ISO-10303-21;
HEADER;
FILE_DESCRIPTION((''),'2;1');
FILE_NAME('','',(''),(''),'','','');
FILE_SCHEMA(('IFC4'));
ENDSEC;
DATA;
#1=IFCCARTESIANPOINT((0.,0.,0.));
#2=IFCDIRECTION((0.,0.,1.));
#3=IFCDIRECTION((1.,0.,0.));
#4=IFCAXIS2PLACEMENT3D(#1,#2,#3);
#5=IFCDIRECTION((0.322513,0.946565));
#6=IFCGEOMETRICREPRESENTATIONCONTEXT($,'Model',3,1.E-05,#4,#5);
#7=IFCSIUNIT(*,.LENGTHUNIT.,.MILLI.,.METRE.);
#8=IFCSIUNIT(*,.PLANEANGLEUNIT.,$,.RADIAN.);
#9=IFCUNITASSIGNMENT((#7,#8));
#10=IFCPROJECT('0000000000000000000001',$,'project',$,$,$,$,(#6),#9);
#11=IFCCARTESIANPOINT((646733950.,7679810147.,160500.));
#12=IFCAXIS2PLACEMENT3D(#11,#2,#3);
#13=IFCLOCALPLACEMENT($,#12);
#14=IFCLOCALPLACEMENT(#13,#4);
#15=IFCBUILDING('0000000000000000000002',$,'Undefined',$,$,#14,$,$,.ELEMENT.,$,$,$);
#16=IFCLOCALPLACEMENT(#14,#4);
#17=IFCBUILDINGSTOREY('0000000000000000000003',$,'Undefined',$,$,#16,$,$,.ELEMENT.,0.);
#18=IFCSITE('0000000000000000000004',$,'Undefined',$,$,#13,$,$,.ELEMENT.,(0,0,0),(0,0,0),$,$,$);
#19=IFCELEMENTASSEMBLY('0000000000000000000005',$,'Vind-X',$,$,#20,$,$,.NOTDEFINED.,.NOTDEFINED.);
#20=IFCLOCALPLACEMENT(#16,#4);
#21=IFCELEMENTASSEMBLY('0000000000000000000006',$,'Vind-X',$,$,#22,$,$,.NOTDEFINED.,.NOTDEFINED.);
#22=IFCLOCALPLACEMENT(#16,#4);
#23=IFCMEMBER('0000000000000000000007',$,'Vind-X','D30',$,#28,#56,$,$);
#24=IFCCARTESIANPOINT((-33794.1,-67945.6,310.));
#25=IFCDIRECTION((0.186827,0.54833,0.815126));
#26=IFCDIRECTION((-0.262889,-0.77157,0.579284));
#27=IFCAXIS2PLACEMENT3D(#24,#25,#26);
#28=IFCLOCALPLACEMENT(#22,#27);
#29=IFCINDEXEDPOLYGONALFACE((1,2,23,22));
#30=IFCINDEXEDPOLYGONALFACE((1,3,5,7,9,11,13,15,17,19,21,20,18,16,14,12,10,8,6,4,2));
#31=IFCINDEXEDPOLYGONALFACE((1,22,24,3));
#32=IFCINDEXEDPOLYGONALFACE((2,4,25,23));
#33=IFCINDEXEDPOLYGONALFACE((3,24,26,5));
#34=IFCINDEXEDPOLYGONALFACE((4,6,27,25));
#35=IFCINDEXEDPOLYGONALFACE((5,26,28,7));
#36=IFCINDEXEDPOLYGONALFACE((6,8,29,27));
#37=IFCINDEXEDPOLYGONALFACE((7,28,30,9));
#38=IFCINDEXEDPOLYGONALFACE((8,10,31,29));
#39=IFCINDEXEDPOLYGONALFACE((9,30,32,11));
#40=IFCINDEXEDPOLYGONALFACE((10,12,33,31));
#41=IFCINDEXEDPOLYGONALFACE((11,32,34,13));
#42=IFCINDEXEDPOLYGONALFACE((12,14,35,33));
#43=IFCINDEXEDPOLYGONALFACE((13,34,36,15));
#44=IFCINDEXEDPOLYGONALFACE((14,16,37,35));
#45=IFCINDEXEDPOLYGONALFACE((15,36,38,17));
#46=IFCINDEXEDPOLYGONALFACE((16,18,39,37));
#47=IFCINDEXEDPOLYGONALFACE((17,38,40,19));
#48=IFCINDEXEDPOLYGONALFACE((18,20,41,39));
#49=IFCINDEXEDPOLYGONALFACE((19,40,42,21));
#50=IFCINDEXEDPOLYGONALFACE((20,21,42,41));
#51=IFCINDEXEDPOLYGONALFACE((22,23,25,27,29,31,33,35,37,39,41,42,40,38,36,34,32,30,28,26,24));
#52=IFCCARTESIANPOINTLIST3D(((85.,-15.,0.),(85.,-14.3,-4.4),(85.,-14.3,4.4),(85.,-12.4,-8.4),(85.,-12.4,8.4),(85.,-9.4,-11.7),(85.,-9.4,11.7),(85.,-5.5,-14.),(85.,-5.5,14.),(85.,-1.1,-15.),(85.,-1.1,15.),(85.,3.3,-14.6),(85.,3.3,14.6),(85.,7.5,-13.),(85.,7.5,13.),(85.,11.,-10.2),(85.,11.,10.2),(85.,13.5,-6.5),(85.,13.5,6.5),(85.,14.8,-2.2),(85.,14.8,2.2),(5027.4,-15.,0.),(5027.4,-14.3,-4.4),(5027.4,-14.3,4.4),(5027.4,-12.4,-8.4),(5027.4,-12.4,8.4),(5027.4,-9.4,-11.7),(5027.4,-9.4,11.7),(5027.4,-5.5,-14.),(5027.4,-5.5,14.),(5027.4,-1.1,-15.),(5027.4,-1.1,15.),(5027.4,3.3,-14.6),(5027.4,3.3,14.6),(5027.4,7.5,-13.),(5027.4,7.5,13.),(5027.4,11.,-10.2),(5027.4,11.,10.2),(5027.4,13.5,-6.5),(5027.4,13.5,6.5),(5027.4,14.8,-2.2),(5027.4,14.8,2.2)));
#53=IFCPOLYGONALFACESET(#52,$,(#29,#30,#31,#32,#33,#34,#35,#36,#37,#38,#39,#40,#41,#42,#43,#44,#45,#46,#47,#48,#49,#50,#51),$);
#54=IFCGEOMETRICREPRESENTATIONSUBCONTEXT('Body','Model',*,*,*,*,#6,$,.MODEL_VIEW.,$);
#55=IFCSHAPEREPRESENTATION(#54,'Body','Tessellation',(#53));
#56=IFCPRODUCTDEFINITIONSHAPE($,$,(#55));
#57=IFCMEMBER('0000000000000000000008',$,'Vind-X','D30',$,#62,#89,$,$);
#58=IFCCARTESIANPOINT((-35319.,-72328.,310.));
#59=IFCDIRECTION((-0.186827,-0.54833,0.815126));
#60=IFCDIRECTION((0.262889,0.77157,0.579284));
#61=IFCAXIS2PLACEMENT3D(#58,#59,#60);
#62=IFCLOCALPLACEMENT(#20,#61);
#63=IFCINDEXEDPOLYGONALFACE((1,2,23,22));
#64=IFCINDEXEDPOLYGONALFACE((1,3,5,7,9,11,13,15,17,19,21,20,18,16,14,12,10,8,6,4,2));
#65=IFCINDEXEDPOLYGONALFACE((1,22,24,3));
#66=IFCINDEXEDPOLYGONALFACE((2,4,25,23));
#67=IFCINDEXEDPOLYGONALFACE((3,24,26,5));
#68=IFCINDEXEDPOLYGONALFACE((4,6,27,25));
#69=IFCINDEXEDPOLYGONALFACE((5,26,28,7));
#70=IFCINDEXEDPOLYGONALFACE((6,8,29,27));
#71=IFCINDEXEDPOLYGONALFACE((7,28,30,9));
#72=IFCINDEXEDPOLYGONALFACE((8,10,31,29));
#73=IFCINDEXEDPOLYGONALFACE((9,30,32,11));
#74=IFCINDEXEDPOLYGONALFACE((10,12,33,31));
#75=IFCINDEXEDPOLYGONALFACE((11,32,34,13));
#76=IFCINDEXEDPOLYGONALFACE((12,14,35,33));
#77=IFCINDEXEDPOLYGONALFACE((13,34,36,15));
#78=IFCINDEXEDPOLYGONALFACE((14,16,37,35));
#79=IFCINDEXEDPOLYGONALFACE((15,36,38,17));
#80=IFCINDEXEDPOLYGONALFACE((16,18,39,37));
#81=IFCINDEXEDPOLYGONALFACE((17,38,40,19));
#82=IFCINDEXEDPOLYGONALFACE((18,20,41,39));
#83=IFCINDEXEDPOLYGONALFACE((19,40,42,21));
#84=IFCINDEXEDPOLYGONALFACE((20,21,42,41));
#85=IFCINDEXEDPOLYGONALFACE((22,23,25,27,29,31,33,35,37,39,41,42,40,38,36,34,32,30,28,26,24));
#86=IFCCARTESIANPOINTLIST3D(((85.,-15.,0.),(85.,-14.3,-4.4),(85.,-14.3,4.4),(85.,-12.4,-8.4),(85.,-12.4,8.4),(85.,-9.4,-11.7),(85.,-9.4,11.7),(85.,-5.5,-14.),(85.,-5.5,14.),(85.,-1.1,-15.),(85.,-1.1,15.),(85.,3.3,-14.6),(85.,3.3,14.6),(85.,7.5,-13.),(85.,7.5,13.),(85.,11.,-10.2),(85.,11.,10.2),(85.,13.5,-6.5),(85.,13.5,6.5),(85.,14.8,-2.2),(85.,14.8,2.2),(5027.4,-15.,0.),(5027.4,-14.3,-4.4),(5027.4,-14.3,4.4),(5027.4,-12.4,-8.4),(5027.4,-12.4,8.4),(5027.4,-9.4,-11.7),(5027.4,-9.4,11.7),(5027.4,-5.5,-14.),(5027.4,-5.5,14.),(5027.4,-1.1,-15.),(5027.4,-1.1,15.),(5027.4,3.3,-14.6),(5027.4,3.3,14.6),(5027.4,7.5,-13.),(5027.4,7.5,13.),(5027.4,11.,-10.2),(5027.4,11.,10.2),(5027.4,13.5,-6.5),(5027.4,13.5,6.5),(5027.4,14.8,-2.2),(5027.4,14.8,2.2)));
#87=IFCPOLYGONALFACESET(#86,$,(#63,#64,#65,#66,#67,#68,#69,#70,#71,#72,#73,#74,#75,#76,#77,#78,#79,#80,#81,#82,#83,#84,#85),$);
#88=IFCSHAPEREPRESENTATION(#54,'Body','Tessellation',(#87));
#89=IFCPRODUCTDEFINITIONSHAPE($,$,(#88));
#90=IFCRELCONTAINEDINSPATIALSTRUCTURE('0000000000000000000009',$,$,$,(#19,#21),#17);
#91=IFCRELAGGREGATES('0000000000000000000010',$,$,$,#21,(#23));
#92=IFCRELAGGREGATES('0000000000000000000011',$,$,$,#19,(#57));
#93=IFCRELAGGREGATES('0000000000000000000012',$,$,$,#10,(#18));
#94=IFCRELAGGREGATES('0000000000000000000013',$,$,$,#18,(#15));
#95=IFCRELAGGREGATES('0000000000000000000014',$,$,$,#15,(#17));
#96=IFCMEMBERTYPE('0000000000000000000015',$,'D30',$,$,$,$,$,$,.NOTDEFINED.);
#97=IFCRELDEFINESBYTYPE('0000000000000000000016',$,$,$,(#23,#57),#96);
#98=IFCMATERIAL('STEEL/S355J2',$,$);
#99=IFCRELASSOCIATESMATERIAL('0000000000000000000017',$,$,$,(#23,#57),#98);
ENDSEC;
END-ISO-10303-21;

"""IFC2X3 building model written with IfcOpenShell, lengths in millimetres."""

from ifc_helpers import new_model, si_unit, direction, frame, origin_with_axes, origin_2d_with_axis, place, context, subcontext, project, spatial, circle, extrude, clip, halfspace, material, type_object, element, aggregate, save


model = new_model("IFC2X3")

# Units and contexts
model_context = context("Model", 3, precision=1e-05, world=origin_with_axes(), true_north=direction((0.322513, 0.946565)))
body_context = subcontext(model_context, "Body", "Model", "MODEL_VIEW")
ifc_project = project(units=[si_unit("LENGTHUNIT", "METRE", prefix="MILLI"), si_unit("PLANEANGLEUNIT", "RADIAN")], contexts=[model_context])

# Site, building, storey
site_placement = place(None, frame((646733950.0, 7679810147.0, 160500.0), z_axis=(0.0, 0.0, 1.0), x_axis=(1.0, 0.0, 0.0)))
site = spatial("IfcSite", under=ifc_project, at=site_placement, Name="Undefined", CompositionType="ELEMENT", RefLatitude=(0, 0, 0), RefLongitude=(0, 0, 0))
building_placement = place(site_placement, origin_with_axes())
building = spatial("IfcBuilding", under=site, at=building_placement, Name="Undefined", CompositionType="ELEMENT")
storey_placement = place(building_placement, origin_with_axes())
storey = spatial("IfcBuildingStorey", under=building, at=storey_placement, Name="Undefined", CompositionType="ELEMENT", Elevation=0.0)

# Element assemblies, member
assembly_1_placement = place(storey_placement, origin_with_axes())
assembly_1 = element("IfcElementAssembly", 1, at=assembly_1_placement, inside=storey, Name="Vind-X", AssemblyPlace="NOTDEFINED", PredefinedType="NOTDEFINED")
ifc_material_1 = material(Name="STEEL/S355J2")
member_type_1 = type_object("IfcMemberType", Name="D30", PredefinedType="NOTDEFINED")
assembly_2_placement = place(storey_placement, origin_with_axes())
assembly_2 = element("IfcElementAssembly", 2, at=assembly_2_placement, inside=storey, Name="Vind-X", AssemblyPlace="NOTDEFINED", PredefinedType="NOTDEFINED")
member_1_placement = place(assembly_2_placement, frame((-33794.1, -67945.6, 310.0), z_axis=(0.186827, 0.54833, 0.815126), x_axis=(-0.262889, -0.77157, 0.579284)))
member_1 = element("IfcMember", 3, at=member_1_placement, type_object=member_type_1, material=ifc_material_1, Name="Vind-X", Description="D30", context=body_context, shape_type="Clipping", body=[
    clip(clip(extrude(circle(Radius=15.0, at=origin_2d_with_axis()), frame((5692.4, 0.0, 0.0), z_axis=(-1.0, 0.0, 0.0), x_axis=(0.0, -1.0, 0.0)), (0.0, 0.0, 1.0), 5692.4), halfspace(frame((5027.4, -6.0, 10.2), z_axis=(1.0, 0.0, 0.0), x_axis=(0.0, 1.0, 0.0)), False)), halfspace(frame((85.0, -6.0, 16.0), z_axis=(1.0, 0.0, 0.0), x_axis=(0.0, 1.0, 0.0)), True)),
])

# Member
member_2_placement = place(assembly_1_placement, frame((-35319.0, -72328.0, 310.0), z_axis=(-0.186827, -0.54833, 0.815126), x_axis=(0.262889, 0.77157, 0.579284)))
member_2 = element("IfcMember", 4, at=member_2_placement, type_object=member_type_1, material=ifc_material_1, Name="Vind-X", Description="D30", context=body_context, shape_type="Clipping", body=[
    clip(clip(extrude(circle(Radius=15.0, at=origin_2d_with_axis()), frame((5692.4, 0.0, 0.0), z_axis=(-1.0, 0.0, 0.0), x_axis=(0.0, -1.0, 0.0)), (0.0, 0.0, 1.0), 5692.4), halfspace(frame((5027.4, -6.0, 10.2), z_axis=(1.0, 0.0, 0.0), x_axis=(0.0, 1.0, 0.0)), False)), halfspace(frame((85.0, -6.0, 16.0), z_axis=(1.0, 0.0, 0.0), x_axis=(0.0, 1.0, 0.0)), True)),
])

aggregate(assembly_2, [member_1])
aggregate(assembly_1, [member_2])

save(model, "model.ifc")
